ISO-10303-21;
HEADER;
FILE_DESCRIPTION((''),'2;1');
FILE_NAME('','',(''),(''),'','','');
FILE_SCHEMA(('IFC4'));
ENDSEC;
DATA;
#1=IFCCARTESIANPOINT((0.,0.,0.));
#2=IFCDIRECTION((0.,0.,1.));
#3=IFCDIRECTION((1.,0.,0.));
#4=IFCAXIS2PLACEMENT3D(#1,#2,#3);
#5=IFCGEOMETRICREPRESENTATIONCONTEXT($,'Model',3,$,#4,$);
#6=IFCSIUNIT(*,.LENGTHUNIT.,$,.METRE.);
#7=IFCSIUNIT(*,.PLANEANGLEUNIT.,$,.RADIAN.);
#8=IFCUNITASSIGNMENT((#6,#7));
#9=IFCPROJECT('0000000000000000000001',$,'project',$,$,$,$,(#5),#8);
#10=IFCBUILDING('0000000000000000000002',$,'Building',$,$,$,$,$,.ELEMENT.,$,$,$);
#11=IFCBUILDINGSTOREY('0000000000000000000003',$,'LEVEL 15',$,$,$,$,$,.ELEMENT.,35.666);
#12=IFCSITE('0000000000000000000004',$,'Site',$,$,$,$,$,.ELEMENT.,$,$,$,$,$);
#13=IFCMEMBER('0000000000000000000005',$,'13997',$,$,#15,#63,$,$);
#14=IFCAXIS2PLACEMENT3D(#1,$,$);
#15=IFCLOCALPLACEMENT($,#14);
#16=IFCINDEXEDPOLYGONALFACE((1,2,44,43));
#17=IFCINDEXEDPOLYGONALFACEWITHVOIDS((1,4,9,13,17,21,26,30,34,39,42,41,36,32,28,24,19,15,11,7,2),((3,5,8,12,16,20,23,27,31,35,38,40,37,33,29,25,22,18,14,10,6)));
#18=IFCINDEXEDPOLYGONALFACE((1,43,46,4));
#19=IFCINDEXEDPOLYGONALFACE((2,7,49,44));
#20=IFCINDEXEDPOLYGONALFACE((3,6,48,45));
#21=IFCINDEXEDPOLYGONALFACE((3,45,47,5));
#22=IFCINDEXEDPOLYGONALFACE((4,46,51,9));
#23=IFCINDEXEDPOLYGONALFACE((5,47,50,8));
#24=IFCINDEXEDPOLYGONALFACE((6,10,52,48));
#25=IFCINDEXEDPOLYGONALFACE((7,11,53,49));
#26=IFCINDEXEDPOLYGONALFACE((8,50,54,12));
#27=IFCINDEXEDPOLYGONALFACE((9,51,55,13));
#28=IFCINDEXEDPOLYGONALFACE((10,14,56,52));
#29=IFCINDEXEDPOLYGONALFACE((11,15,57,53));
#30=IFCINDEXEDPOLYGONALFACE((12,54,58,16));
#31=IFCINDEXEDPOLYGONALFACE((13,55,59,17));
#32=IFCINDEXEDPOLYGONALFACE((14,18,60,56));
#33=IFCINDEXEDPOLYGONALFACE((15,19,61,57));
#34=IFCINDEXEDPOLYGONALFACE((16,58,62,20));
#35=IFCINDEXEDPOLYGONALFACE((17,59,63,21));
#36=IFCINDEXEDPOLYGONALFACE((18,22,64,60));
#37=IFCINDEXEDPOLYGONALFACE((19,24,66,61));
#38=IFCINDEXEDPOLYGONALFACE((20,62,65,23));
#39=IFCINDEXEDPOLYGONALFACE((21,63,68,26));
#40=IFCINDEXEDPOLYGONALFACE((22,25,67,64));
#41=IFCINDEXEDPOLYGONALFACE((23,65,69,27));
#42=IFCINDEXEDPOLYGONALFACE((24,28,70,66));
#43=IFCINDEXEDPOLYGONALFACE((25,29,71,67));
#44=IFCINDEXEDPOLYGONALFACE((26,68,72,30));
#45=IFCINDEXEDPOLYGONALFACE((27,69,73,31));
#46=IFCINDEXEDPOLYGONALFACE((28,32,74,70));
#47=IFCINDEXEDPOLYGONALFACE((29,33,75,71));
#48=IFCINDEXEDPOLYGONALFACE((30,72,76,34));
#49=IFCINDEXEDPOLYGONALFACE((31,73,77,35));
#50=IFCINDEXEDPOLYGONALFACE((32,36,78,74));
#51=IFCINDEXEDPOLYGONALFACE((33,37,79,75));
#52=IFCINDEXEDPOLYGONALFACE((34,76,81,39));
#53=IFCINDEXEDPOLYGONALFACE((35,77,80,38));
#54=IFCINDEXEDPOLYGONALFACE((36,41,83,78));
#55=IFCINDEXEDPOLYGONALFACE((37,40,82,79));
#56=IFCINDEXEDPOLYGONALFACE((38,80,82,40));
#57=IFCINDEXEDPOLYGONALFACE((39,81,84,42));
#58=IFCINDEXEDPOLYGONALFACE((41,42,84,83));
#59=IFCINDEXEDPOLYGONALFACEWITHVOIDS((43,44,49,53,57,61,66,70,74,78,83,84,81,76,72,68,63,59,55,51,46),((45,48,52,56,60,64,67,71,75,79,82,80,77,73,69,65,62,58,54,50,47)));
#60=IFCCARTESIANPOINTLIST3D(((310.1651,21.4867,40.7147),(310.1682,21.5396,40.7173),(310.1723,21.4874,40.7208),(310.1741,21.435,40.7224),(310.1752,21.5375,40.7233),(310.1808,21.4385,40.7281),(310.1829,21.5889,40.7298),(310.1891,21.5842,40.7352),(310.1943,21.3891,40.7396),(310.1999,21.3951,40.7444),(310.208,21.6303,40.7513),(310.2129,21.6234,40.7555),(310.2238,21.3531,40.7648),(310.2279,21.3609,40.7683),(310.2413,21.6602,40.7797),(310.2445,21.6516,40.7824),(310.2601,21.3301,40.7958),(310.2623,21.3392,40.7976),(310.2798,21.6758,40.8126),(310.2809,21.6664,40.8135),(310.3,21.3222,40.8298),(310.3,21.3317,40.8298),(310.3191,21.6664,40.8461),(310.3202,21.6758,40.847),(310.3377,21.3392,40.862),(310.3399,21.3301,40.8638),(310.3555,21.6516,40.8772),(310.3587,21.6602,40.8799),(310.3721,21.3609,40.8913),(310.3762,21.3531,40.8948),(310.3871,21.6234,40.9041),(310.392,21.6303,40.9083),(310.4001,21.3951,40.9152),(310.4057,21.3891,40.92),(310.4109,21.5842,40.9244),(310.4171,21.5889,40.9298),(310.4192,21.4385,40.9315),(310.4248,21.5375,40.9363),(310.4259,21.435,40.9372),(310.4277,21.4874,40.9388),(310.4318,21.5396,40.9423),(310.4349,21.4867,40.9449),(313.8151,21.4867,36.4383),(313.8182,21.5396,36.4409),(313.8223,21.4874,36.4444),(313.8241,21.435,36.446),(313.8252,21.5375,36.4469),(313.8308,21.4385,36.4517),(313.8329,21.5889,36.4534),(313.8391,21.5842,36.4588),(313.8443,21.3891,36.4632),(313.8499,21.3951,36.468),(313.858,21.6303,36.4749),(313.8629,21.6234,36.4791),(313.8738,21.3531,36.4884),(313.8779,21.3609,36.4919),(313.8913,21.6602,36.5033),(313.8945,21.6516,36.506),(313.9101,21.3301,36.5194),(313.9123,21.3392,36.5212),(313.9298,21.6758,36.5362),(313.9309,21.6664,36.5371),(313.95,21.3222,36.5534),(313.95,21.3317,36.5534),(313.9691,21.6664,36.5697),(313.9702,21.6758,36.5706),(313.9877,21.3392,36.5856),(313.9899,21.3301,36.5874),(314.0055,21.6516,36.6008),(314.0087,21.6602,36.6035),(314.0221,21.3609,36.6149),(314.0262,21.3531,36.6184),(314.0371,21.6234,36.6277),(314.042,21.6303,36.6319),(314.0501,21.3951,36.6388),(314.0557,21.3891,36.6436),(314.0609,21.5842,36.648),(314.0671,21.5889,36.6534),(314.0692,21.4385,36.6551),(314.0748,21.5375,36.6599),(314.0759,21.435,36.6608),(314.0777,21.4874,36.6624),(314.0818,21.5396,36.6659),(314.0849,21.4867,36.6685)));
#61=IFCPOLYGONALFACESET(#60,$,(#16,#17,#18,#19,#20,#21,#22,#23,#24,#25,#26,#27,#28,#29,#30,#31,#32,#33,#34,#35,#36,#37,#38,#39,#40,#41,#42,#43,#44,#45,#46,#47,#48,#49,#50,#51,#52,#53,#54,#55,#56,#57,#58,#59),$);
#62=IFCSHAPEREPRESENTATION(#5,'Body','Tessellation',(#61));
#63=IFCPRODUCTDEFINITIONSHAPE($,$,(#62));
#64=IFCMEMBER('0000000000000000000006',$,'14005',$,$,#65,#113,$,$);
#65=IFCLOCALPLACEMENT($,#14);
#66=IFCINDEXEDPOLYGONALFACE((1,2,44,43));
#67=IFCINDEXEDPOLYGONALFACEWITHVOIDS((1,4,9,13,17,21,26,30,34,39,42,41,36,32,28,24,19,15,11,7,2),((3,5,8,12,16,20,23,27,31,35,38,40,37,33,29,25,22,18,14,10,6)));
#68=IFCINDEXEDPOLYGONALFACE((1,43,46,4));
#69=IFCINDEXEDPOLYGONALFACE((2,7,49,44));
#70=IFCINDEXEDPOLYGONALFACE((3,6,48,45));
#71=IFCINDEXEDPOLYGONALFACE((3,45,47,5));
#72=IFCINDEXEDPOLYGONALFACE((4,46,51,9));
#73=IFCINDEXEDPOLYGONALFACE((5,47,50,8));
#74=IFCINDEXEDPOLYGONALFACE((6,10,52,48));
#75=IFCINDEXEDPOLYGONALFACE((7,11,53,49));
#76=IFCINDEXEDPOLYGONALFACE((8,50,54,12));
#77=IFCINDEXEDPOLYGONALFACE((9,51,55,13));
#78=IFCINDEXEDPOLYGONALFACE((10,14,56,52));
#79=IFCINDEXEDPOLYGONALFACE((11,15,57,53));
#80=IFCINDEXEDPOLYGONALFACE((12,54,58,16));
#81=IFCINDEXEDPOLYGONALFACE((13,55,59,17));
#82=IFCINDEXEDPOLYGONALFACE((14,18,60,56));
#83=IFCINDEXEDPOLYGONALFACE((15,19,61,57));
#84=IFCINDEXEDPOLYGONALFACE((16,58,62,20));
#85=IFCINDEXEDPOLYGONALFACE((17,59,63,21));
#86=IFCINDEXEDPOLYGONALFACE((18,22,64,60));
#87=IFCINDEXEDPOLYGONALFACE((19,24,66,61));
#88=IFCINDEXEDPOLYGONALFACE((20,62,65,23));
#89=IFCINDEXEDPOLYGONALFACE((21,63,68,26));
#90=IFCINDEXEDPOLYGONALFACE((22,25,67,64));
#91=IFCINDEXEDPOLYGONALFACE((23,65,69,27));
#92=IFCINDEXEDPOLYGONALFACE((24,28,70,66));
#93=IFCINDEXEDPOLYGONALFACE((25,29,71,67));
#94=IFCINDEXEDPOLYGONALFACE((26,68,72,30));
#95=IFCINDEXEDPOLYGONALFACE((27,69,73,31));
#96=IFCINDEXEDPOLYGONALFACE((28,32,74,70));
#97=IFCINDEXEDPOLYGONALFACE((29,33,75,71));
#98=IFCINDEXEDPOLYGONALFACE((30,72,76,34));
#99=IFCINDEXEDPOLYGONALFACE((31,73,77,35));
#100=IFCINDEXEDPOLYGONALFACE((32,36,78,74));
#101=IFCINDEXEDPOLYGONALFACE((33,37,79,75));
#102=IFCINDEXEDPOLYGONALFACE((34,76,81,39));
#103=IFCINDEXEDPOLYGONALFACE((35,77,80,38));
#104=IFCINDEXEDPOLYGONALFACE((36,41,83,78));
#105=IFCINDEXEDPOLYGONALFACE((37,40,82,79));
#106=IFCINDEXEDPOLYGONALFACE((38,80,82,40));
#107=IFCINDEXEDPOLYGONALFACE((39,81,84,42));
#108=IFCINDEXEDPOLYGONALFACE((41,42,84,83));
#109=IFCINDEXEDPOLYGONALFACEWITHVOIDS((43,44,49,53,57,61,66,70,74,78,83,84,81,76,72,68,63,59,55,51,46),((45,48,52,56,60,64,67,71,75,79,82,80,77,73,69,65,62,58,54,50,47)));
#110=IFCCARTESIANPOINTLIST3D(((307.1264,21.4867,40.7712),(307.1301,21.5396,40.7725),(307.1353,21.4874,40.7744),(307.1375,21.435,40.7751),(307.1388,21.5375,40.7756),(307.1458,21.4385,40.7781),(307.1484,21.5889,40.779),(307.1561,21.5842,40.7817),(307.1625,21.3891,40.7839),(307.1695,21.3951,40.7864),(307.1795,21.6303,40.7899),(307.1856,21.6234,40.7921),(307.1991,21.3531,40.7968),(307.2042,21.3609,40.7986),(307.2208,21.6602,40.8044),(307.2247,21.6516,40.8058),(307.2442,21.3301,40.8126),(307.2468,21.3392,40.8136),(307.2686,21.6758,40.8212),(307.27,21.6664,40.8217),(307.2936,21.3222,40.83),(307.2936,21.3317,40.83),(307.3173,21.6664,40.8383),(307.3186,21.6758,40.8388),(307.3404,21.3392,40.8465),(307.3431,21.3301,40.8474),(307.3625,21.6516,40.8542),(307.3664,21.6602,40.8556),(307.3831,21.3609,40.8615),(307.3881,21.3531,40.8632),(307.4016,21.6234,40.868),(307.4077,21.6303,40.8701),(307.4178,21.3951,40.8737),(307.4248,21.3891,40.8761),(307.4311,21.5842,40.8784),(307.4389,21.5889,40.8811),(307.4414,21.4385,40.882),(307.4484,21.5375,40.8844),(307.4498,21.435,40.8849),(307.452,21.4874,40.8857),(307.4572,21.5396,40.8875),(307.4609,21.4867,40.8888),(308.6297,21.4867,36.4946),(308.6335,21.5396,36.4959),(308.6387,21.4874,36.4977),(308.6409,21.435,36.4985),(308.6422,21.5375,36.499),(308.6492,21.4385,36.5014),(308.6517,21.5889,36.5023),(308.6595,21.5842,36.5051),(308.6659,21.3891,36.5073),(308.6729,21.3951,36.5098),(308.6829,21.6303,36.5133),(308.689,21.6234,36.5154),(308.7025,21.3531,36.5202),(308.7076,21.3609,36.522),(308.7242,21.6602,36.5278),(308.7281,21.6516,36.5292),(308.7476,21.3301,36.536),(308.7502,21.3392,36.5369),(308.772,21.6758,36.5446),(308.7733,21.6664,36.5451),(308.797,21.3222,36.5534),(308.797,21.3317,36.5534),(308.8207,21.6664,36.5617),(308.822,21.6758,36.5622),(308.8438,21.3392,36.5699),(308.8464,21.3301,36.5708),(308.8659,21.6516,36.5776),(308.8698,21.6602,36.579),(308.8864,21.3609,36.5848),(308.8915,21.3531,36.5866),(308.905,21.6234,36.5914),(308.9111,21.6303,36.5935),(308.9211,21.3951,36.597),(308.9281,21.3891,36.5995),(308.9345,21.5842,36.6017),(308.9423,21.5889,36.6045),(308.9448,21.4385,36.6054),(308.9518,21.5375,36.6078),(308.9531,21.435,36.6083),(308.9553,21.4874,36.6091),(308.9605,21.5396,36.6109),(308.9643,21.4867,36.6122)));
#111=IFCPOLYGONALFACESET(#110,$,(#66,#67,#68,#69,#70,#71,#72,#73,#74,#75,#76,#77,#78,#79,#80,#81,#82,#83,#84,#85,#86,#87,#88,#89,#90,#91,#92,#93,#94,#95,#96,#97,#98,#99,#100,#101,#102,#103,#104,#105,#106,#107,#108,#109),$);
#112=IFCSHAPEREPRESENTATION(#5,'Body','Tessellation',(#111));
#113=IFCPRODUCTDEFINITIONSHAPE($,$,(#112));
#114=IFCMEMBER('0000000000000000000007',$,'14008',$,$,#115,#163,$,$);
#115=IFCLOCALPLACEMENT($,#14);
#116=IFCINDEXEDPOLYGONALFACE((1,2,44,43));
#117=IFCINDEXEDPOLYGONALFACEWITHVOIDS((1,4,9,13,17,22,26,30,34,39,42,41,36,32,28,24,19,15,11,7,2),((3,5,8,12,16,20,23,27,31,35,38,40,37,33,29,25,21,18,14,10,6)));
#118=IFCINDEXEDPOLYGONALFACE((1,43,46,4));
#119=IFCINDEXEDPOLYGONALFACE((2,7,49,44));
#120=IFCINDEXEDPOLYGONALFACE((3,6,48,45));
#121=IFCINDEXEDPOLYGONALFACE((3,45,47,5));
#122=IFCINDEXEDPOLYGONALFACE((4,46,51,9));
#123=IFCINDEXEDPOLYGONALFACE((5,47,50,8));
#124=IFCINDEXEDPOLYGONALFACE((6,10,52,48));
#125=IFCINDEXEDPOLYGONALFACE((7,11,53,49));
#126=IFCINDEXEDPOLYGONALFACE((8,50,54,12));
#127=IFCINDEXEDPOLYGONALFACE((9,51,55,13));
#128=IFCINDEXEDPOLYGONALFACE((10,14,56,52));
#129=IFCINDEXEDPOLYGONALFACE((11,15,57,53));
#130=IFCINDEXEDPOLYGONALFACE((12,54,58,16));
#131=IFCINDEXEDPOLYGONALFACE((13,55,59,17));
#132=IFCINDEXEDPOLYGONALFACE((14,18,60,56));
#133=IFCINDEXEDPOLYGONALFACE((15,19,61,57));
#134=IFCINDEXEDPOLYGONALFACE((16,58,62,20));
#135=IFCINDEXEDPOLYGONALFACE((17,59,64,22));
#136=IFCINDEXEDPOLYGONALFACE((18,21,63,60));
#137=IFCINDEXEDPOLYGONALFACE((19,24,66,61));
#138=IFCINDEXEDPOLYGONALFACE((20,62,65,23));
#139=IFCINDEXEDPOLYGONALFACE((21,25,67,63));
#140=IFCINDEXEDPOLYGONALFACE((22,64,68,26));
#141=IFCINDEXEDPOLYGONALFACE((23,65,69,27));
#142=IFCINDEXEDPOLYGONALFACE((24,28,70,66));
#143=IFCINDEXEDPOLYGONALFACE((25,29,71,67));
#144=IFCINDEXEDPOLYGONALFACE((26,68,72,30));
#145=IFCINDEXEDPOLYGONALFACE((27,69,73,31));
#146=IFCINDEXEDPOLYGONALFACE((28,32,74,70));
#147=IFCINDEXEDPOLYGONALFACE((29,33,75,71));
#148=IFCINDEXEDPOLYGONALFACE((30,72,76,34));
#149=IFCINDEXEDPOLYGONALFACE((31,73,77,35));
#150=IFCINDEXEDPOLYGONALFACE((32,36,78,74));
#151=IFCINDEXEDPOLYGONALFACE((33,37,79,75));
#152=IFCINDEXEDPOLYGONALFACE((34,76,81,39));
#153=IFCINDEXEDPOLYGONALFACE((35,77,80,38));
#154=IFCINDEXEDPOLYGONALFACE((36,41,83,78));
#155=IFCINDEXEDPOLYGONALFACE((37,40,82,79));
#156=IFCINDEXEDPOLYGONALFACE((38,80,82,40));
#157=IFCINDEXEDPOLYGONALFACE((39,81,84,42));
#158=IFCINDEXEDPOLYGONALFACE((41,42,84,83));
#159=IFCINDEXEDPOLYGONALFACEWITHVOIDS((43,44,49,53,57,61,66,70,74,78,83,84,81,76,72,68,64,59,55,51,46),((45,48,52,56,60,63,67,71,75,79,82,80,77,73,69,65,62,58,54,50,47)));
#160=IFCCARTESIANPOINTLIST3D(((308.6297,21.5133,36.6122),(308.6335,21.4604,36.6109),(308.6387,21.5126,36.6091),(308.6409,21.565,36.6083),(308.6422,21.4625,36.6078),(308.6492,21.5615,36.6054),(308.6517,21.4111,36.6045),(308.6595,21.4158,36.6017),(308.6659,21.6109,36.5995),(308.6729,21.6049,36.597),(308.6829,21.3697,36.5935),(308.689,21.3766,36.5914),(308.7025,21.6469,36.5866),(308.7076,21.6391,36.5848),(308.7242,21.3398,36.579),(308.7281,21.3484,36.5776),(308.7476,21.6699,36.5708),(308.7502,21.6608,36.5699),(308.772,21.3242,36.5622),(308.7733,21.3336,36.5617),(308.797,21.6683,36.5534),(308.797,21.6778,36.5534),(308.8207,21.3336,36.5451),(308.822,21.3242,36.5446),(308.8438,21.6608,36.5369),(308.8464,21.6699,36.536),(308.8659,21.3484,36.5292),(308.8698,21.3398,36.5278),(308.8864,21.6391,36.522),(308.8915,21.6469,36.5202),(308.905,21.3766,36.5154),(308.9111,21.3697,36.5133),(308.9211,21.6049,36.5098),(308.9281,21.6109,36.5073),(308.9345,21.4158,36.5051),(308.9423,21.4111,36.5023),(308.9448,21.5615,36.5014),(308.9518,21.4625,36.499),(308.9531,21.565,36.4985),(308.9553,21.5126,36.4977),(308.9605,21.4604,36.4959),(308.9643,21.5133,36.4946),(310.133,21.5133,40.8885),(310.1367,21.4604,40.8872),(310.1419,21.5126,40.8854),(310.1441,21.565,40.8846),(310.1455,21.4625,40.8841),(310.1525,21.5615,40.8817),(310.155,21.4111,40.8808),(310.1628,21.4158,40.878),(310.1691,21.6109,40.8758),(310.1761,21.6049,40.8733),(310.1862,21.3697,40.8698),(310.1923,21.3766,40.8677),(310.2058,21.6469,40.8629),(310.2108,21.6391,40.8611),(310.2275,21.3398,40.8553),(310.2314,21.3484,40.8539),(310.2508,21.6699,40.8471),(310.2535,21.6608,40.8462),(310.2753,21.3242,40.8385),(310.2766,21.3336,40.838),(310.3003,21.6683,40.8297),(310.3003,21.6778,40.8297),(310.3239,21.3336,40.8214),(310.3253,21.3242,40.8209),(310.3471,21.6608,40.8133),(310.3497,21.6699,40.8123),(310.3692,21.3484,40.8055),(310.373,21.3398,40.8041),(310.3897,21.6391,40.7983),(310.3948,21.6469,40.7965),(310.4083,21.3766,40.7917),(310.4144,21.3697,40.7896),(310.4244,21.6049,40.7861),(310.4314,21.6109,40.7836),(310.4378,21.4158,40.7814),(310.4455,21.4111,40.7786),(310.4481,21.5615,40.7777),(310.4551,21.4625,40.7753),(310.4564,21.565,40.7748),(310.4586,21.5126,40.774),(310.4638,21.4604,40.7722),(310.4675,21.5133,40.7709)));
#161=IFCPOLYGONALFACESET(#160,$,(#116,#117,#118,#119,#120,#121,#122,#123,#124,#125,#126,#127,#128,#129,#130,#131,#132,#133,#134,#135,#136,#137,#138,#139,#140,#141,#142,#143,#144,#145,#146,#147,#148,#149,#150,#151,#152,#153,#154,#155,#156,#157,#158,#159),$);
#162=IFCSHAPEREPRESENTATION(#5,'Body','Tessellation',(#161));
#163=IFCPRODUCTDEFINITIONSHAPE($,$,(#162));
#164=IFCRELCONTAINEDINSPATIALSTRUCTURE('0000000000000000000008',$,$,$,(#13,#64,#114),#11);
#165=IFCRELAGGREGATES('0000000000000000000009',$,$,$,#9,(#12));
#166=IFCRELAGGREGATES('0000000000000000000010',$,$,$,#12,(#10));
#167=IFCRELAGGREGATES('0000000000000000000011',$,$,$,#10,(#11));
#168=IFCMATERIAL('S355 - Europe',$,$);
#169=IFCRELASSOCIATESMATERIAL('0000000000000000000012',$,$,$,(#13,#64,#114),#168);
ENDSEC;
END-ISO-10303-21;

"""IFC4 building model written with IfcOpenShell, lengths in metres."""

from ifc_helpers import new_model, si_unit, frame, origin_with_axes, origin_2d_with_axis, place, context, project, spatial, hollow_circle, extrude, material, material_profile, profile_set, profile_usage, element, save


model = new_model("IFC4")

# Units and contexts
model_context = context("Model", 3, world=origin_with_axes())
ifc_project = project(units=[si_unit("LENGTHUNIT", "METRE"), si_unit("PLANEANGLEUNIT", "RADIAN")], contexts=[model_context])

# Site, building, storey
site = spatial("IfcSite", under=ifc_project, Name="Site", CompositionType="ELEMENT")
building = spatial("IfcBuilding", under=site, Name="Building", CompositionType="ELEMENT")
storey = spatial("IfcBuildingStorey", under=building, Name="LEVEL 15", CompositionType="ELEMENT", Elevation=35.666)

# Shared definitions
ifc_material = material(Name="S355 - Europe")

# Members
ifc_material_profile_1 = material_profile(ifc_material, hollow_circle(Radius=0.1778, WallThickness=0.0095, at=origin_2d_with_axis()))
ifc_profile_set_1 = profile_set([ifc_material_profile_1])
ifc_profile_usage_1 = profile_usage(ifc_profile_set_1, cardinal=10)
member_1_placement = place(None, frame((313.95, 21.5, 36.5534), z_axis=(-0.649202, 0.0, 0.760616), x_axis=(0.0, -1.0, 0.0)))
element("IfcMember", 1, at=member_1_placement, inside=storey, material=ifc_profile_usage_1, Name="13997", context=model_context, shape_type="SweptSolid", body=[
    extrude(hollow_circle(Radius=0.1778, WallThickness=0.0095, at=origin_2d_with_axis()), origin_with_axes(), (0.0, 0.0, 1.0), 5.6223),
])
ifc_material_profile_2 = material_profile(ifc_material, hollow_circle(Radius=0.1778, WallThickness=0.0095, at=origin_2d_with_axis()))
ifc_profile_set_2 = profile_set([ifc_material_profile_2])
ifc_profile_usage_2 = profile_usage(ifc_profile_set_2, cardinal=10)
member_2_placement = place(None, frame((308.797, 21.5, 36.5534), z_axis=(-0.331639, 0.0, 0.943406), x_axis=(0.0, -1.0, 0.0)))
element("IfcMember", 2, at=member_2_placement, inside=storey, material=ifc_profile_usage_2, Name="14005", context=model_context, shape_type="SweptSolid", body=[
    extrude(hollow_circle(Radius=0.1778, WallThickness=0.0095, at=origin_2d_with_axis()), origin_with_axes(), (0.0, 0.0, 1.0), 4.5332),
])
ifc_material_profile_3 = material_profile(ifc_material, hollow_circle(Radius=0.1778, WallThickness=0.0095, at=origin_2d_with_axis()))
ifc_profile_set_3 = profile_set([ifc_material_profile_3])
ifc_profile_usage_3 = profile_usage(ifc_profile_set_3, cardinal=10)
member_3_placement = place(None, frame((308.797, 21.5, 36.5534), z_axis=(0.331639, 0.0, 0.943406), x_axis=(0.0, 1.0, 0.0)))
element("IfcMember", 3, at=member_3_placement, inside=storey, material=ifc_profile_usage_3, Name="14008", context=model_context, shape_type="SweptSolid", body=[
    extrude(hollow_circle(Radius=0.1778, WallThickness=0.0095, at=origin_2d_with_axis()), origin_with_axes(), (0.0, 0.0, 1.0), 4.5328),
])

save(model, "model.ifc")
